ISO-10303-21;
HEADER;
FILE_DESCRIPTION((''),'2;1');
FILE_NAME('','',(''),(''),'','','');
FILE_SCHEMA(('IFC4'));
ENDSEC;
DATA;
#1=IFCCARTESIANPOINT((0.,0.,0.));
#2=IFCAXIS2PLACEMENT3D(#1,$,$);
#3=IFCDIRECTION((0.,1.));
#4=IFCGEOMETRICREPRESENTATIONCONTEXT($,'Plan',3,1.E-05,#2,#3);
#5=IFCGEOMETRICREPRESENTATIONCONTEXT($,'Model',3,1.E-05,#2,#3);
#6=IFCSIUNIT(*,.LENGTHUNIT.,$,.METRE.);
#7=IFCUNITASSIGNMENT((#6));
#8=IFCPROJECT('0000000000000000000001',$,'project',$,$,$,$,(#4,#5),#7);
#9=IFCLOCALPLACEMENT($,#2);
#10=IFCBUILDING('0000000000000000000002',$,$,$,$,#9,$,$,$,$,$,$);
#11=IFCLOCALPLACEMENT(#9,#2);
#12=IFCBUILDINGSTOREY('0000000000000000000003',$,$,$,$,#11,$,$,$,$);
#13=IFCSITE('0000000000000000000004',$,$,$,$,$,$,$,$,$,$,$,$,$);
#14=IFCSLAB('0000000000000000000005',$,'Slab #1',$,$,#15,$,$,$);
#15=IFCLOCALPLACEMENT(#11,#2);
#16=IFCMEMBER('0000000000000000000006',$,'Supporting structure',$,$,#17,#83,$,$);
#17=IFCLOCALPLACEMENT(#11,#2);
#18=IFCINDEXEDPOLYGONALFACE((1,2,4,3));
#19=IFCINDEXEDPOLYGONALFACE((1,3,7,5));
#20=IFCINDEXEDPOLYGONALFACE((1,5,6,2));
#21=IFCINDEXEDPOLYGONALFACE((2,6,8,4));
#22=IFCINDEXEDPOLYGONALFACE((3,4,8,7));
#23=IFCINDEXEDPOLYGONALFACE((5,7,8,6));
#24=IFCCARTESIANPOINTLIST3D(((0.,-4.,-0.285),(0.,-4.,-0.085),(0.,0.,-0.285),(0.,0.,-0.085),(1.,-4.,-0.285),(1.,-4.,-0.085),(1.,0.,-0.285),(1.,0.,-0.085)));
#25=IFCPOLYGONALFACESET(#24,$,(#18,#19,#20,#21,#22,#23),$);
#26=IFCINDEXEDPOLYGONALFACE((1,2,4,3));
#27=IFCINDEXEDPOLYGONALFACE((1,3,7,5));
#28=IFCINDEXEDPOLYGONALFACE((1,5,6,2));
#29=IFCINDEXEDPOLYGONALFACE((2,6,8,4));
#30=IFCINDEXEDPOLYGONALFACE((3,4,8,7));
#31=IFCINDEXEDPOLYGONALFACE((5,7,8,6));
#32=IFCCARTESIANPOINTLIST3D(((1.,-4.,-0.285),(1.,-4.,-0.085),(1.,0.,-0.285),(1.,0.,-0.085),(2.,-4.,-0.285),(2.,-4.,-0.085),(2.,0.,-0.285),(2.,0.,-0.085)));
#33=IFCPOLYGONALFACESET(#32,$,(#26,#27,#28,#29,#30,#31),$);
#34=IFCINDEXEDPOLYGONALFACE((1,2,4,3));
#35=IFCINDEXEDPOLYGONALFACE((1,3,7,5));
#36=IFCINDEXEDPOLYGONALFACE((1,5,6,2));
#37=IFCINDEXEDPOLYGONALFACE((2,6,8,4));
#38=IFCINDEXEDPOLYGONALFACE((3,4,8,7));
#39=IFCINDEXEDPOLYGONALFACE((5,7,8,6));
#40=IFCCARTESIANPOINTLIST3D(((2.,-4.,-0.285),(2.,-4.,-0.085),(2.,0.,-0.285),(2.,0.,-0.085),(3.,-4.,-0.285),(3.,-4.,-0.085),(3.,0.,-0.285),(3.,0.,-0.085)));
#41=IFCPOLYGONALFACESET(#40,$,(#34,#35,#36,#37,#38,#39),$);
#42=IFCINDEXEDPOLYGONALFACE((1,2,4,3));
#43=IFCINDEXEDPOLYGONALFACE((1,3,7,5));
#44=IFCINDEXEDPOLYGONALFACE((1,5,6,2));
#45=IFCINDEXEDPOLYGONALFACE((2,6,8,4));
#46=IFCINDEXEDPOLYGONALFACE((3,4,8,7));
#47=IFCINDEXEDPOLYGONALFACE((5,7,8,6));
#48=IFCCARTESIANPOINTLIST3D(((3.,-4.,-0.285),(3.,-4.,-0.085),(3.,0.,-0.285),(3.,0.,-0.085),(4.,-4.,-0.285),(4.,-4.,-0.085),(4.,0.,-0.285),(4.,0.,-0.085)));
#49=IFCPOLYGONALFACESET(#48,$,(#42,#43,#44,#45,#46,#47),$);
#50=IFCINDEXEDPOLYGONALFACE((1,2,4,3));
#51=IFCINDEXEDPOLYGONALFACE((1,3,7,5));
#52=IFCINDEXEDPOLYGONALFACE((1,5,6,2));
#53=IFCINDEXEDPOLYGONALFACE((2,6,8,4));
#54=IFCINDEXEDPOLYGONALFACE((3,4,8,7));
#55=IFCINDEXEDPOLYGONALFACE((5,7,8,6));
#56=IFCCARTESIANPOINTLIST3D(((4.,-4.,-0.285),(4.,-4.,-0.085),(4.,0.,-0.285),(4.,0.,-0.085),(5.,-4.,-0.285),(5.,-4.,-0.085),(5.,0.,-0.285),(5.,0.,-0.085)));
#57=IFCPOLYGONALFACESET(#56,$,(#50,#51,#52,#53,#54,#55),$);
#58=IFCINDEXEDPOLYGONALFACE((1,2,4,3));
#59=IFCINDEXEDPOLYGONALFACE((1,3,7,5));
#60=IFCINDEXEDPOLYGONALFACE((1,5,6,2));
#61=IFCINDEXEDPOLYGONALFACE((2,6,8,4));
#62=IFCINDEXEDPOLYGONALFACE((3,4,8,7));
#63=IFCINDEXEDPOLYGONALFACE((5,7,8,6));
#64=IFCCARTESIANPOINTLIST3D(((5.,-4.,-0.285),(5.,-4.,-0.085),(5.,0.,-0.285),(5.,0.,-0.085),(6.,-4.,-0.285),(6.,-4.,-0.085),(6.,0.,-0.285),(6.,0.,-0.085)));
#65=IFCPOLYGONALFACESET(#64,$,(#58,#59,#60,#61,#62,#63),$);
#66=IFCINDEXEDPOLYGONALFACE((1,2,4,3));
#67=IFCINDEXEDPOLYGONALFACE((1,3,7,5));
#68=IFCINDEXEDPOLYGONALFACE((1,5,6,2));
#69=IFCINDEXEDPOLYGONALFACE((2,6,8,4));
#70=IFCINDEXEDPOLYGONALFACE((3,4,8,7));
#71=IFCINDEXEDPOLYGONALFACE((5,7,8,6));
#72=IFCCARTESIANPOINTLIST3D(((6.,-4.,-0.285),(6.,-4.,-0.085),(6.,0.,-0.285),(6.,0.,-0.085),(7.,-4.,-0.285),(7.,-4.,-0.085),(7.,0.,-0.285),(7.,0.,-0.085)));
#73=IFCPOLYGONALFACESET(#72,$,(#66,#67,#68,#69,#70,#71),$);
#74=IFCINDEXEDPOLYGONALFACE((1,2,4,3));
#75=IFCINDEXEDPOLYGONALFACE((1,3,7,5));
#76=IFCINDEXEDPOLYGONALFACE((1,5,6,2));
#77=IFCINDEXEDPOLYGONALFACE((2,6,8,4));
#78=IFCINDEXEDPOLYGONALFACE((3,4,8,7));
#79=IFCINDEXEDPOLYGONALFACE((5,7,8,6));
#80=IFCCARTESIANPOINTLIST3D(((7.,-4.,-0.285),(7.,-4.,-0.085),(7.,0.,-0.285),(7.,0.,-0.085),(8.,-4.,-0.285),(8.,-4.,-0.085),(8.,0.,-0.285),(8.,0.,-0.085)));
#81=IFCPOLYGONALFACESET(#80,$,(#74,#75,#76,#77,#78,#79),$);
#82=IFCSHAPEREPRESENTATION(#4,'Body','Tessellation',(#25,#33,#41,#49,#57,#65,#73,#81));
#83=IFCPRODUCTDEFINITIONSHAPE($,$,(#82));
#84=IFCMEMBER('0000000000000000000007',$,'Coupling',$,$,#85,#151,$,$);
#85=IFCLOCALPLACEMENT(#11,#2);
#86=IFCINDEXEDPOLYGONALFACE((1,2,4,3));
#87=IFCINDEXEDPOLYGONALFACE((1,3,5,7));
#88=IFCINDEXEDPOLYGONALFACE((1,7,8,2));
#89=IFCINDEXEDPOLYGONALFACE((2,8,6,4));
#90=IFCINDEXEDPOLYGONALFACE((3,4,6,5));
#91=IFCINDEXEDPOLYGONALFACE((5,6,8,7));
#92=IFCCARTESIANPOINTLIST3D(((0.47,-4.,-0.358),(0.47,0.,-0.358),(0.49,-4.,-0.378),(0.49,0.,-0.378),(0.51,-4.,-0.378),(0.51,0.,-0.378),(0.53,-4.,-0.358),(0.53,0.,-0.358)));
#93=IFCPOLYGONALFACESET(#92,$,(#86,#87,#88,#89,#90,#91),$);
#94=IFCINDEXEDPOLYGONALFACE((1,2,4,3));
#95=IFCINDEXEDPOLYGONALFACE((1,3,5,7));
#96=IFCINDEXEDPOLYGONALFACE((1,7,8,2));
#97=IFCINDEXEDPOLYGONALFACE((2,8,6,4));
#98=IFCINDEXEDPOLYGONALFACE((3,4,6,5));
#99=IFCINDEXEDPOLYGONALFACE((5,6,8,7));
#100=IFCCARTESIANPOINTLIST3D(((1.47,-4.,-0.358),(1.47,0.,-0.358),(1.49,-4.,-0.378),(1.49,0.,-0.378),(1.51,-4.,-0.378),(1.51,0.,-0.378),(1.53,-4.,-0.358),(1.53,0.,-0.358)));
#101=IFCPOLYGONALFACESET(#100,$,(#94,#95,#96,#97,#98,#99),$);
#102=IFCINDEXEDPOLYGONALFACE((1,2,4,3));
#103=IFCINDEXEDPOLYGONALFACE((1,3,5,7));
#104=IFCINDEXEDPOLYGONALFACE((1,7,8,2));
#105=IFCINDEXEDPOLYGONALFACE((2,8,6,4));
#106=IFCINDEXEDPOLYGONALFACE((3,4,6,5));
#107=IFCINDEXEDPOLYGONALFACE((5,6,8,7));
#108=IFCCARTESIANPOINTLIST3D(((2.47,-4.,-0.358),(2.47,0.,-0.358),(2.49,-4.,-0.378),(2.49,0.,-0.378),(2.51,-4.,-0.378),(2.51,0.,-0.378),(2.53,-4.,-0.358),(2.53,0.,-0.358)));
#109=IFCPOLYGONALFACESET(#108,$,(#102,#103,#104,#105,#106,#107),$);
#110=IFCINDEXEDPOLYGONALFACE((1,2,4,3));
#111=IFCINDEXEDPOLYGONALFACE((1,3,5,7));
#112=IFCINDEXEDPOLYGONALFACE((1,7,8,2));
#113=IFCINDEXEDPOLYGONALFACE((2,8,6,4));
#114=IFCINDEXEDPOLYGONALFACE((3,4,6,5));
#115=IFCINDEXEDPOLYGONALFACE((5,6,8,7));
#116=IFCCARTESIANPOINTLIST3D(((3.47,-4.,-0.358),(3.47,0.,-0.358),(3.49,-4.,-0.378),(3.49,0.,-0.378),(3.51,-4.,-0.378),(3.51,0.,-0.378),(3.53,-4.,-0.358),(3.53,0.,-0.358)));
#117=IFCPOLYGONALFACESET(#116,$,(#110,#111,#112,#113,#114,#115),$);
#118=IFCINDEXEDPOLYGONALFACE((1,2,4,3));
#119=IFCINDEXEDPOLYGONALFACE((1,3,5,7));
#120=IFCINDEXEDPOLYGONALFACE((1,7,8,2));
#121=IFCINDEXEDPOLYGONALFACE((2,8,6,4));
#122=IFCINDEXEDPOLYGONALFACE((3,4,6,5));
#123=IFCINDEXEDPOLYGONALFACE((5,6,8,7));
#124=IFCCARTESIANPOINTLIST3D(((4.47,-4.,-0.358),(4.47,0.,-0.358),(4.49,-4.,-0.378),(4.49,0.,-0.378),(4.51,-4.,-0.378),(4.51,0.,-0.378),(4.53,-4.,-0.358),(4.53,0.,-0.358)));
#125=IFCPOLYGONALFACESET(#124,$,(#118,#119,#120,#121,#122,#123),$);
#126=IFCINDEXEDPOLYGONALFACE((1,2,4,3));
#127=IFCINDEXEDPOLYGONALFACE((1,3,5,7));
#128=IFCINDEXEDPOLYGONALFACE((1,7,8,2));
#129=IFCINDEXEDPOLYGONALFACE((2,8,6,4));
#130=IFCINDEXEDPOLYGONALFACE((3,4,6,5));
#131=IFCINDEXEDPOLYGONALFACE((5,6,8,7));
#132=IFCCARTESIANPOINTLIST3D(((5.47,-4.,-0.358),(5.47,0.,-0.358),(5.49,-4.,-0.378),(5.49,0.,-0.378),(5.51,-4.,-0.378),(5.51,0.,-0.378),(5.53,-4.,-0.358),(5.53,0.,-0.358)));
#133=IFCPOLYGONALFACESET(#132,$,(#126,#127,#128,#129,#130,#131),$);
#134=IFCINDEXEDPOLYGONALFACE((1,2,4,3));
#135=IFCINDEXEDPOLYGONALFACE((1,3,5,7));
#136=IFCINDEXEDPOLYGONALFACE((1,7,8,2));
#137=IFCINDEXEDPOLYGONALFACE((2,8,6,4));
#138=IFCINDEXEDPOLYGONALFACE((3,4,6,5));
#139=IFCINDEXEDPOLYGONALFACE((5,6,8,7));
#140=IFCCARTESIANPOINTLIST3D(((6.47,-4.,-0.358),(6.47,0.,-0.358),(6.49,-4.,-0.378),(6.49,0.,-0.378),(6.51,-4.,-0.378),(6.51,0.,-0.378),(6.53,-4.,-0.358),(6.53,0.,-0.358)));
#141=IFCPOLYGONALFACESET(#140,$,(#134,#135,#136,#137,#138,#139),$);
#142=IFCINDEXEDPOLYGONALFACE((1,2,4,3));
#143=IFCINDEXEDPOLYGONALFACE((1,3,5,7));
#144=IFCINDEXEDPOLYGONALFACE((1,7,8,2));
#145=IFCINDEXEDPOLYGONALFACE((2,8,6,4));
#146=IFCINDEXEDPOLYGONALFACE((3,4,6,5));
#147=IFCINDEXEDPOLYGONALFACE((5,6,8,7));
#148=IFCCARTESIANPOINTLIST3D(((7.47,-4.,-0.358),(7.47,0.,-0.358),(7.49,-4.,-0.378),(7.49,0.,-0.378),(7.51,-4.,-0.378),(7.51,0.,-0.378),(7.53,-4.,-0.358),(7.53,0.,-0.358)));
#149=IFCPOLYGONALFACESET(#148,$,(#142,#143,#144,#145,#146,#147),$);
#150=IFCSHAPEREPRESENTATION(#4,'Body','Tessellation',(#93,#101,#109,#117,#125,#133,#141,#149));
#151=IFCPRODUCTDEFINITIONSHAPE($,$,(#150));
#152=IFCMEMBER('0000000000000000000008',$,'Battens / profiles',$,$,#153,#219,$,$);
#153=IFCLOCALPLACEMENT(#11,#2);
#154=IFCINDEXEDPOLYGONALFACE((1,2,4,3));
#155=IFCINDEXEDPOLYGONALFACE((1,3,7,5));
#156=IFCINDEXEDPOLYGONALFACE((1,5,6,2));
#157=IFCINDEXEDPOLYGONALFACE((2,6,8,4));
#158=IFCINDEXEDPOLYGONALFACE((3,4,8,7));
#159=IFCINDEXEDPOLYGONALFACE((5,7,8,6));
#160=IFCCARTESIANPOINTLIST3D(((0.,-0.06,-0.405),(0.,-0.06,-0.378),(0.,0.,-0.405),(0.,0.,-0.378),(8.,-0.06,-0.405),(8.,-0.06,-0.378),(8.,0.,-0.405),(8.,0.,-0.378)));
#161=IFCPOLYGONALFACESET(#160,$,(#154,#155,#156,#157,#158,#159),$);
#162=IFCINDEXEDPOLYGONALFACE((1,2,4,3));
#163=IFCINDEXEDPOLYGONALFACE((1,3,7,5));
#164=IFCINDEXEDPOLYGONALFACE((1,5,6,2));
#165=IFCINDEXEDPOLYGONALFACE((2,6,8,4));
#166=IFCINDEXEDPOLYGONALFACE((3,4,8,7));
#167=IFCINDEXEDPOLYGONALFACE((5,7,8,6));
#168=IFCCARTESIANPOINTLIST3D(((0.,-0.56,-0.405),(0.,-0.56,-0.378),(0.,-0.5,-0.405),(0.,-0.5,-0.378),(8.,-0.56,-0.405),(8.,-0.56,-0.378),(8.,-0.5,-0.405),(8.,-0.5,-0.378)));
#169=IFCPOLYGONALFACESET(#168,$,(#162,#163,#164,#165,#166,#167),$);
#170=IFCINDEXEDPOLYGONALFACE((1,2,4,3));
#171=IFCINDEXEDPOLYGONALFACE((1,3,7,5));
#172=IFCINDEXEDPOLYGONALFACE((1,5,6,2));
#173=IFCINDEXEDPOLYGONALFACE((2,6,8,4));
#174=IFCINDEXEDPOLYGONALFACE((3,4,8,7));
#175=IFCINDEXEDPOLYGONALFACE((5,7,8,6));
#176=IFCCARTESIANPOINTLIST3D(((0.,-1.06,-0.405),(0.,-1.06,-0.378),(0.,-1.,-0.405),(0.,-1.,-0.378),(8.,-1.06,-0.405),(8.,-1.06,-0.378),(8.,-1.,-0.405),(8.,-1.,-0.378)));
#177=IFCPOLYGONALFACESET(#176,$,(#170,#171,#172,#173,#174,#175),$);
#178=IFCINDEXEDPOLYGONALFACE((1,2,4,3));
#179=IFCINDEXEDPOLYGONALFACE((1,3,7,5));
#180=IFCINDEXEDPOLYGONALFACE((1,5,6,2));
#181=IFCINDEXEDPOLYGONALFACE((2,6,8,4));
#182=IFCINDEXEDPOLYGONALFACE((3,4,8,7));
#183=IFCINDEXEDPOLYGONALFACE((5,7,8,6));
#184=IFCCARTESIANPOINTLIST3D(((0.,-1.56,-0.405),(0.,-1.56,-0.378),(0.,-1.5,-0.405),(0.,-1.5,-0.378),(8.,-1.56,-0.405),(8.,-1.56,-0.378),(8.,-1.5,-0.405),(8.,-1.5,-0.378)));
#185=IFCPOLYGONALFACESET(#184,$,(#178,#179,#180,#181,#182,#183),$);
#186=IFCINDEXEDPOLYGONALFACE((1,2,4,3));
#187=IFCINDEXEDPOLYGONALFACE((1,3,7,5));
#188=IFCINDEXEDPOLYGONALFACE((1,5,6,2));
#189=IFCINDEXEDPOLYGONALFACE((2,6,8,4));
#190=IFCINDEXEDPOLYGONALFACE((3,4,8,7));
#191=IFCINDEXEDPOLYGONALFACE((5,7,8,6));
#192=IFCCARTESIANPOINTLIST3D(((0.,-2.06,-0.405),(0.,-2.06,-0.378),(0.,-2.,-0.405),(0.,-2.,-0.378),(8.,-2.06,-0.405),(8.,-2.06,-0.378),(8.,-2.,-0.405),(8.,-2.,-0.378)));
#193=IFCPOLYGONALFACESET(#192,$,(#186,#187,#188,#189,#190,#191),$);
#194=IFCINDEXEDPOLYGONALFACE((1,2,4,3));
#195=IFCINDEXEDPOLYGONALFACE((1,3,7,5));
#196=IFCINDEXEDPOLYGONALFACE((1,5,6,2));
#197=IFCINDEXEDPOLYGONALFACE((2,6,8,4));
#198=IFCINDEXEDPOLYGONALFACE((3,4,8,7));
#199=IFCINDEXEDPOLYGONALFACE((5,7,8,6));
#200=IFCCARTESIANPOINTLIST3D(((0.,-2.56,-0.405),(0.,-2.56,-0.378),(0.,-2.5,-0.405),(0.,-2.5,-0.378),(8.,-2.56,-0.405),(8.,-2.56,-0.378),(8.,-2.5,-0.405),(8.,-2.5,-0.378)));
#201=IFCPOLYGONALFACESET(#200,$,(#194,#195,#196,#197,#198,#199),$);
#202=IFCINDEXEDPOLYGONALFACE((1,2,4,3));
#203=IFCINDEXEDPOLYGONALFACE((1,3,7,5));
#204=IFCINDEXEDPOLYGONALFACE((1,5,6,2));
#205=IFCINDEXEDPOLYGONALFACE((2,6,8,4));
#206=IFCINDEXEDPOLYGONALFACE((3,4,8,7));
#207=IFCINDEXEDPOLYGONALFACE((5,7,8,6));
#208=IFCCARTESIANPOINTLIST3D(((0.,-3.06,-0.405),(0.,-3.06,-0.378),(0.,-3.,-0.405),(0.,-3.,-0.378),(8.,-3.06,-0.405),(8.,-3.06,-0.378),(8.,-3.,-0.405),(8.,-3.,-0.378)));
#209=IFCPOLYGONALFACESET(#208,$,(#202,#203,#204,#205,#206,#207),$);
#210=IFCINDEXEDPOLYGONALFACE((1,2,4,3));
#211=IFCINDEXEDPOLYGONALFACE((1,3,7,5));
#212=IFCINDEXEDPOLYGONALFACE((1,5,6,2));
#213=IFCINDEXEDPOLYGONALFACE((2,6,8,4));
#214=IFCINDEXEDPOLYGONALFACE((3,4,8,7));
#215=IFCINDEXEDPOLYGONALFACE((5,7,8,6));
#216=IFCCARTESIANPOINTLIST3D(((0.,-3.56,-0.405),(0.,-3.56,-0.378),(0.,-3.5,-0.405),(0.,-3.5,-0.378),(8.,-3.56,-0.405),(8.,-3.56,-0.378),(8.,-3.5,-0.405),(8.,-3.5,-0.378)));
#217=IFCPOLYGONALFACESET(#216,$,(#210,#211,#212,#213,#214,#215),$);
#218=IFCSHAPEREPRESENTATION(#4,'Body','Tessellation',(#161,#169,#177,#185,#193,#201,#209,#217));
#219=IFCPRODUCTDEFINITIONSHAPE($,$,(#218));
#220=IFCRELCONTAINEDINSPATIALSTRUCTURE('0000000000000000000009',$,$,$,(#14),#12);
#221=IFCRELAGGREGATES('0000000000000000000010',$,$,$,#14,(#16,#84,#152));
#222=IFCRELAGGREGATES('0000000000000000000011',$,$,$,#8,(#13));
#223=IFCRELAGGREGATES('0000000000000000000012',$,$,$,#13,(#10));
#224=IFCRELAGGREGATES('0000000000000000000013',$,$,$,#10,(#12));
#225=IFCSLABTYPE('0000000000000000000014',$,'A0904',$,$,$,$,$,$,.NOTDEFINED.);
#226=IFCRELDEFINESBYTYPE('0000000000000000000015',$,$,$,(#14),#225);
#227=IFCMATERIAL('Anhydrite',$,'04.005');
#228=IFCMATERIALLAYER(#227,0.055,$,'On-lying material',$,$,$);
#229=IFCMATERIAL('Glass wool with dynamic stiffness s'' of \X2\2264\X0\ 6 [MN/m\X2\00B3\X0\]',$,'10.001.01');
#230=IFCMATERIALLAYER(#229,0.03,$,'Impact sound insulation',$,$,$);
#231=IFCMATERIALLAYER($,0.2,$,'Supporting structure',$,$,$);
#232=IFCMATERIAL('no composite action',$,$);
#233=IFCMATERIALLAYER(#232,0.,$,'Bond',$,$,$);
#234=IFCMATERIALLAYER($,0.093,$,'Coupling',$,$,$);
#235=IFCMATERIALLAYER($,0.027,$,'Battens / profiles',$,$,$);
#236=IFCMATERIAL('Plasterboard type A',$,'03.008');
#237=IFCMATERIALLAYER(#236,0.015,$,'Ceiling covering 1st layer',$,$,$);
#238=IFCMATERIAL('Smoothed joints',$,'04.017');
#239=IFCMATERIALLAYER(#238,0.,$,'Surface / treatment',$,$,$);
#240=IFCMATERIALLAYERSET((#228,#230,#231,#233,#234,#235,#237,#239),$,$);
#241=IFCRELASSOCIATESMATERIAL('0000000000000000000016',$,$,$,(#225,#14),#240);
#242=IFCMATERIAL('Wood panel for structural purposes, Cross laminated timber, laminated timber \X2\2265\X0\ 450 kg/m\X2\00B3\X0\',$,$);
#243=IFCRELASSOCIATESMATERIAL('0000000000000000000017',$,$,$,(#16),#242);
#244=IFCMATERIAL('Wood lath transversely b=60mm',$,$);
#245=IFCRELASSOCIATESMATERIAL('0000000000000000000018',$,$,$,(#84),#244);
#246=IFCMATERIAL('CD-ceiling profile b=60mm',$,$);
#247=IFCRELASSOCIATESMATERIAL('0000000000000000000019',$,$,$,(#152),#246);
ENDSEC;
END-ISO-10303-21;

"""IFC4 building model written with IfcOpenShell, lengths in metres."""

from ifc_helpers import new_model, si_unit, direction, frame, frame_2d, origin, place, context, project, spatial, polyline, rectangle, outline, extrude, material, layer, layer_set, type_object, element, aggregate, save


model = new_model("IFC4")

# Units and contexts
plan_context = context("Plan", 3, precision=1e-05, world=origin(), true_north=direction((0.0, 1.0)))
model_context = context("Model", 3, precision=1e-05, world=origin(), true_north=direction((0.0, 1.0)))
ifc_project = project(units=[si_unit("LENGTHUNIT", "METRE")], contexts=[plan_context, model_context])

# Site, building, storey
site = spatial("IfcSite", under=ifc_project)
building_placement = place(None, origin())
building = spatial("IfcBuilding", under=site, at=building_placement)
storey_placement = place(building_placement, origin())
storey = spatial("IfcBuildingStorey", under=building, at=storey_placement)

# Slab, members
ifc_material_1 = material(Name="Anhydrite", Category="04.005")
ifc_layer_1 = layer(ifc_material_1, 0.055, Name="On-lying material")
ifc_material_2 = material(Name="Glass wool with dynamic stiffness s' of ≤ 6 [MN/m³]", Category="10.001.01")
ifc_layer_2 = layer(ifc_material_2, 0.03, Name="Impact sound insulation")
ifc_layer_3 = layer(None, 0.2, Name="Supporting structure")
ifc_material_3 = material(Name="no composite action")
ifc_layer_4 = layer(ifc_material_3, 0.0, Name="Bond")
ifc_layer_5 = layer(None, 0.093, Name="Coupling")
ifc_layer_6 = layer(None, 0.027, Name="Battens / profiles")
ifc_material_4 = material(Name="Plasterboard type A", Category="03.008")
ifc_layer_7 = layer(ifc_material_4, 0.015, Name="Ceiling covering 1st layer")
ifc_material_5 = material(Name="Smoothed joints", Category="04.017")
ifc_layer_8 = layer(ifc_material_5, 0.0, Name="Surface / treatment")
ifc_layer_set = layer_set([ifc_layer_1, ifc_layer_2, ifc_layer_3, ifc_layer_4, ifc_layer_5, ifc_layer_6, ifc_layer_7, ifc_layer_8])
slab_type = type_object("IfcSlabType", Name="A0904", PredefinedType="NOTDEFINED", material=ifc_layer_set)
slab_placement = place(None, frame((0.0, 0.0, 0.0), z_axis=(0.0, 0.0, -1.0), x_axis=(1.0, 0.0, 0.0)))
slab = element("IfcSlab", 1, at=slab_placement, inside=storey, type_object=slab_type, material=ifc_layer_set, Name="Slab #1")
ifc_material_6 = material(Name="Wood panel for structural purposes, Cross laminated timber, laminated timber ≥ 450 kg/m³")
member_1_placement = place(slab_placement, origin())
member_1 = element("IfcMember", 2, at=member_1_placement, material=ifc_material_6, Name="Supporting structure", context=plan_context, shape_type="SweptSolid", body=[
    extrude(rectangle(XDim=1.0, YDim=0.2, at=frame_2d((0.5, 0.1), x_axis=(1.0, 0.0))), frame((0.0, 4.0, 0.085), z_axis=(0.0, -1.0, 0.0), x_axis=(1.0, 0.0, 0.0)), (0.0, 0.0, 1.0), 4.0),
    extrude(rectangle(XDim=1.0, YDim=0.2, at=frame_2d((0.5, 0.1), x_axis=(1.0, 0.0))), frame((1.0, 4.0, 0.085), z_axis=(0.0, -1.0, 0.0), x_axis=(1.0, 0.0, 0.0)), (0.0, 0.0, 1.0), 4.0),
    extrude(rectangle(XDim=1.0, YDim=0.2, at=frame_2d((0.5, 0.1), x_axis=(1.0, 0.0))), frame((2.0, 4.0, 0.085), z_axis=(0.0, -1.0, 0.0), x_axis=(1.0, 0.0, 0.0)), (0.0, 0.0, 1.0), 4.0),
    extrude(rectangle(XDim=1.0, YDim=0.2, at=frame_2d((0.5, 0.1), x_axis=(1.0, 0.0))), frame((3.0, 4.0, 0.085), z_axis=(0.0, -1.0, 0.0), x_axis=(1.0, 0.0, 0.0)), (0.0, 0.0, 1.0), 4.0),
    extrude(rectangle(XDim=1.0, YDim=0.2, at=frame_2d((0.5, 0.1), x_axis=(1.0, 0.0))), frame((4.0, 4.0, 0.085), z_axis=(0.0, -1.0, 0.0), x_axis=(1.0, 0.0, 0.0)), (0.0, 0.0, 1.0), 4.0),
    extrude(rectangle(XDim=1.0, YDim=0.2, at=frame_2d((0.5, 0.1), x_axis=(1.0, 0.0))), frame((5.0, 4.0, 0.085), z_axis=(0.0, -1.0, 0.0), x_axis=(1.0, 0.0, 0.0)), (0.0, 0.0, 1.0), 4.0),
    extrude(rectangle(XDim=1.0, YDim=0.2, at=frame_2d((0.5, 0.1), x_axis=(1.0, 0.0))), frame((6.0, 4.0, 0.085), z_axis=(0.0, -1.0, 0.0), x_axis=(1.0, 0.0, 0.0)), (0.0, 0.0, 1.0), 4.0),
    extrude(rectangle(XDim=1.0, YDim=0.2, at=frame_2d((0.5, 0.1), x_axis=(1.0, 0.0))), frame((7.0, 4.0, 0.085), z_axis=(0.0, -1.0, 0.0), x_axis=(1.0, 0.0, 0.0)), (0.0, 0.0, 1.0), 4.0),
])
ifc_material_7 = material(Name="Wood lath transversely b=60mm")
member_2_placement = place(slab_placement, origin())
member_2 = element("IfcMember", 3, at=member_2_placement, material=ifc_material_7, Name="Coupling", context=plan_context, shape_type="SweptSolid", body=[
    extrude(outline(polyline([(0.0, 0.0), (0.06, 0.0), (0.04, 0.02), (0.02, 0.02), (0.0, 0.0)])), frame((0.47, 4.0, 0.358), z_axis=(0.0, -1.0, 0.0), x_axis=(1.0, 0.0, 0.0)), (0.0, 0.0, 1.0), 4.0),
    extrude(outline(polyline([(0.0, 0.0), (0.06, 0.0), (0.04, 0.02), (0.02, 0.02), (0.0, 0.0)])), frame((1.47, 4.0, 0.358), z_axis=(0.0, -1.0, 0.0), x_axis=(1.0, 0.0, 0.0)), (0.0, 0.0, 1.0), 4.0),
    extrude(outline(polyline([(0.0, 0.0), (0.06, 0.0), (0.04, 0.02), (0.02, 0.02), (0.0, 0.0)])), frame((2.47, 4.0, 0.358), z_axis=(0.0, -1.0, 0.0), x_axis=(1.0, 0.0, 0.0)), (0.0, 0.0, 1.0), 4.0),
    extrude(outline(polyline([(0.0, 0.0), (0.06, 0.0), (0.04, 0.02), (0.02, 0.02), (0.0, 0.0)])), frame((3.47, 4.0, 0.358), z_axis=(0.0, -1.0, 0.0), x_axis=(1.0, 0.0, 0.0)), (0.0, 0.0, 1.0), 4.0),
    extrude(outline(polyline([(0.0, 0.0), (0.06, 0.0), (0.04, 0.02), (0.02, 0.02), (0.0, 0.0)])), frame((4.47, 4.0, 0.358), z_axis=(0.0, -1.0, 0.0), x_axis=(1.0, 0.0, 0.0)), (0.0, 0.0, 1.0), 4.0),
    extrude(outline(polyline([(0.0, 0.0), (0.06, 0.0), (0.04, 0.02), (0.02, 0.02), (0.0, 0.0)])), frame((5.47, 4.0, 0.358), z_axis=(0.0, -1.0, 0.0), x_axis=(1.0, 0.0, 0.0)), (0.0, 0.0, 1.0), 4.0),
    extrude(outline(polyline([(0.0, 0.0), (0.06, 0.0), (0.04, 0.02), (0.02, 0.02), (0.0, 0.0)])), frame((6.47, 4.0, 0.358), z_axis=(0.0, -1.0, 0.0), x_axis=(1.0, 0.0, 0.0)), (0.0, 0.0, 1.0), 4.0),
    extrude(outline(polyline([(0.0, 0.0), (0.06, 0.0), (0.04, 0.02), (0.02, 0.02), (0.0, 0.0)])), frame((7.47, 4.0, 0.358), z_axis=(0.0, -1.0, 0.0), x_axis=(1.0, 0.0, 0.0)), (0.0, 0.0, 1.0), 4.0),
])
ifc_material_8 = material(Name="CD-ceiling profile b=60mm")
member_3_placement = place(slab_placement, origin())
member_3 = element("IfcMember", 4, at=member_3_placement, material=ifc_material_8, Name="Battens / profiles", context=plan_context, shape_type="SweptSolid", body=[
    extrude(rectangle(XDim=0.06, YDim=0.027, at=frame_2d((0.03, 0.0135), x_axis=(1.0, 0.0))), frame((0.0, 0.0, 0.378), z_axis=(1.0, 0.0, 0.0), x_axis=(0.0, 1.0, 0.0)), (0.0, 0.0, 1.0), 8.0),
    extrude(rectangle(XDim=0.06, YDim=0.027, at=frame_2d((0.03, 0.0135), x_axis=(1.0, 0.0))), frame((0.0, 0.5, 0.378), z_axis=(1.0, 0.0, 0.0), x_axis=(0.0, 1.0, 0.0)), (0.0, 0.0, 1.0), 8.0),
    extrude(rectangle(XDim=0.06, YDim=0.027, at=frame_2d((0.03, 0.0135), x_axis=(1.0, 0.0))), frame((0.0, 1.0, 0.378), z_axis=(1.0, 0.0, 0.0), x_axis=(0.0, 1.0, 0.0)), (0.0, 0.0, 1.0), 8.0),
    extrude(rectangle(XDim=0.06, YDim=0.027, at=frame_2d((0.03, 0.0135), x_axis=(1.0, 0.0))), frame((0.0, 1.5, 0.378), z_axis=(1.0, 0.0, 0.0), x_axis=(0.0, 1.0, 0.0)), (0.0, 0.0, 1.0), 8.0),
    extrude(rectangle(XDim=0.06, YDim=0.027, at=frame_2d((0.03, 0.0135), x_axis=(1.0, 0.0))), frame((0.0, 2.0, 0.378), z_axis=(1.0, 0.0, 0.0), x_axis=(0.0, 1.0, 0.0)), (0.0, 0.0, 1.0), 8.0),
    extrude(rectangle(XDim=0.06, YDim=0.027, at=frame_2d((0.03, 0.0135), x_axis=(1.0, 0.0))), frame((0.0, 2.5, 0.378), z_axis=(1.0, 0.0, 0.0), x_axis=(0.0, 1.0, 0.0)), (0.0, 0.0, 1.0), 8.0),
    extrude(rectangle(XDim=0.06, YDim=0.027, at=frame_2d((0.03, 0.0135), x_axis=(1.0, 0.0))), frame((0.0, 3.0, 0.378), z_axis=(1.0, 0.0, 0.0), x_axis=(0.0, 1.0, 0.0)), (0.0, 0.0, 1.0), 8.0),
    extrude(rectangle(XDim=0.06, YDim=0.027, at=frame_2d((0.03, 0.0135), x_axis=(1.0, 0.0))), frame((0.0, 3.5, 0.378), z_axis=(1.0, 0.0, 0.0), x_axis=(0.0, 1.0, 0.0)), (0.0, 0.0, 1.0), 8.0),
])
aggregate(slab, [member_1, member_2, member_3])

save(model, "model.ifc")
